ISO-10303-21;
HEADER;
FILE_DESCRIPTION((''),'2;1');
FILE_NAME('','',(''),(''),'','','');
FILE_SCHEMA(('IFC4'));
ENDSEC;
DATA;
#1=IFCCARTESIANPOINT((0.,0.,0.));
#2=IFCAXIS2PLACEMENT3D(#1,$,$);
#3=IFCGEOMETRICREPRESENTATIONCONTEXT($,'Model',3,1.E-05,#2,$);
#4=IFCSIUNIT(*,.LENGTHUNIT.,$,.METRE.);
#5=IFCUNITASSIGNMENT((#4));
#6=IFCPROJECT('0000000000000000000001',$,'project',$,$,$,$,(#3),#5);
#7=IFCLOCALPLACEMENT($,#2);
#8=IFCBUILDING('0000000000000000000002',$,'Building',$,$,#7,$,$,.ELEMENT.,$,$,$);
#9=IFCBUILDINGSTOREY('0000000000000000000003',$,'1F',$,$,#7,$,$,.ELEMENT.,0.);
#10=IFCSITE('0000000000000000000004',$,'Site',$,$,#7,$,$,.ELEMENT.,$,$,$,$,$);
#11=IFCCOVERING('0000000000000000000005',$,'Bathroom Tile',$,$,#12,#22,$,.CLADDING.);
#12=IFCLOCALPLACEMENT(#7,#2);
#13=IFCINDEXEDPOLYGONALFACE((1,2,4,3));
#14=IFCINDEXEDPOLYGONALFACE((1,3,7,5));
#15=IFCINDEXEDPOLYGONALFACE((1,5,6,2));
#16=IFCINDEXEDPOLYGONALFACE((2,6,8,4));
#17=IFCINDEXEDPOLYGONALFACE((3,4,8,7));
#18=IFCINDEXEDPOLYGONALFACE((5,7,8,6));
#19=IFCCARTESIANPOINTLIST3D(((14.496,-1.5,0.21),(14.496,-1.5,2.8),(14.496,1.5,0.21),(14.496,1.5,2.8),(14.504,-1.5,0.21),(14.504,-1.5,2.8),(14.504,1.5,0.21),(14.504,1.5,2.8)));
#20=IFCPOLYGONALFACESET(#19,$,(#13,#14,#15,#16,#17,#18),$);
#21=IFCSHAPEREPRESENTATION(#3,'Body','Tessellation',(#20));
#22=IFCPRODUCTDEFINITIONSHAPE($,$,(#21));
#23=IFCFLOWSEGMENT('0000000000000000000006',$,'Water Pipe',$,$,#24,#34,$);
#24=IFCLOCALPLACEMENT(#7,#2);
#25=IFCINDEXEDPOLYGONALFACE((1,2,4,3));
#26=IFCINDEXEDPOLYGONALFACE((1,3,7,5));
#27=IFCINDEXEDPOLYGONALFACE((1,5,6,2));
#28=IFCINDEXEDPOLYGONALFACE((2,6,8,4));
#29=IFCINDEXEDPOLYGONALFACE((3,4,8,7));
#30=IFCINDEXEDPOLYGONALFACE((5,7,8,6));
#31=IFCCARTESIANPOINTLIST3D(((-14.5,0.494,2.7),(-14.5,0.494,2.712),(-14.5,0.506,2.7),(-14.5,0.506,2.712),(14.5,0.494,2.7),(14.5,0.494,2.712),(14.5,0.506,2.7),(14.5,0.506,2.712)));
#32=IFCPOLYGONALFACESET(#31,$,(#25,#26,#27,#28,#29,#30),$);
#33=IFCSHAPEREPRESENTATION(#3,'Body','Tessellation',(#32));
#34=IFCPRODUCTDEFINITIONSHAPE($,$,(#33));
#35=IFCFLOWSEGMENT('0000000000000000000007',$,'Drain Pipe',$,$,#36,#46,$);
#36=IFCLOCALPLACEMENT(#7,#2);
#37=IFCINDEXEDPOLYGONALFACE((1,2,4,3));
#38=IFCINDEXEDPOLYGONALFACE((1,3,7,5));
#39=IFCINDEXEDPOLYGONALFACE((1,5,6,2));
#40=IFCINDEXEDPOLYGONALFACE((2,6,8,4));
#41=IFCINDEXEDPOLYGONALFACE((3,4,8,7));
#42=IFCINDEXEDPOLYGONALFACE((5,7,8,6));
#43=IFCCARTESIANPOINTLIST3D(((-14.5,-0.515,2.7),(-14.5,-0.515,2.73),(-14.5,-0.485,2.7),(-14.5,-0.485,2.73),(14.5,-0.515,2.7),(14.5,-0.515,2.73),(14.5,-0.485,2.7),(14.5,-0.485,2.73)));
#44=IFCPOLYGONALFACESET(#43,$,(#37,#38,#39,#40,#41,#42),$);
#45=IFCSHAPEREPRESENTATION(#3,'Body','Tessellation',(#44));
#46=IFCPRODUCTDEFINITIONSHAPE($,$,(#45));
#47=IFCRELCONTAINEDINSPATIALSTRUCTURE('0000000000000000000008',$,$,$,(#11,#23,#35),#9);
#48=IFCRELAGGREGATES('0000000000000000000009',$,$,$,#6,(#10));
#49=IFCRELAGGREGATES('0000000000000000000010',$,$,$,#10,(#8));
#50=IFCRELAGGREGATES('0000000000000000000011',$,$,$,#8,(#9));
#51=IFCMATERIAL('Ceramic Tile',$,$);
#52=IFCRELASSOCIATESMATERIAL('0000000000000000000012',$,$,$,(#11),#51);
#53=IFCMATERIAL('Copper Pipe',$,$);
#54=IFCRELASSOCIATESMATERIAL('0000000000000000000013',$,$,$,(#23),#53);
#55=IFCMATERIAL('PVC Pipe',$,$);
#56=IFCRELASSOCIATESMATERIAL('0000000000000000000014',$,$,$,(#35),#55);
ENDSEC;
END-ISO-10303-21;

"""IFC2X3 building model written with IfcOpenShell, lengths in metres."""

from ifc_helpers import new_model, si_unit, frame, origin, origin_2d, place, context, project, spatial, rectangle, extrude, material, element, save


model = new_model("IFC2X3")

# Units and contexts
model_context = context("Model", 3, precision=1e-05, world=origin())
ifc_project = project(units=[si_unit("LENGTHUNIT", "METRE")], contexts=[model_context])

# Site, building, storey
placement = place(None, origin())
site = spatial("IfcSite", under=ifc_project, at=placement, Name="Site", CompositionType="ELEMENT")
building = spatial("IfcBuilding", under=site, at=placement, Name="Building", CompositionType="ELEMENT")
storey = spatial("IfcBuildingStorey", under=building, at=placement, Name="1F", CompositionType="ELEMENT", Elevation=0.0)

# Covering
ifc_material_1 = material(Name="Ceramic Tile")
covering_1_placement = place(None, frame((14.5, 0.0, 0.21)))
element("IfcCovering", 1, at=covering_1_placement, inside=storey, material=ifc_material_1, Name="Bathroom Tile", PredefinedType="CLADDING", context=model_context, shape_type="SweptSolid", body=[
    extrude(rectangle(XDim=0.008, YDim=3.0, at=origin_2d()), origin(), (0.0, 0.0, 1.0), 2.59),
])

# Flow segments
ifc_material_2 = material(Name="Copper Pipe")
flow_segment_1_placement = place(None, frame((0.0, 0.5, 2.7)))
element("IfcFlowSegment", 2, at=flow_segment_1_placement, inside=storey, material=ifc_material_2, Name="Water Pipe", context=model_context, shape_type="SweptSolid", body=[
    extrude(rectangle(XDim=29.0, YDim=0.012, at=origin_2d()), origin(), (0.0, 0.0, 1.0), 0.012),
])
ifc_material_3 = material(Name="PVC Pipe")
flow_segment_2_placement = place(None, frame((0.0, -0.5, 2.7)))
element("IfcFlowSegment", 3, at=flow_segment_2_placement, inside=storey, material=ifc_material_3, Name="Drain Pipe", context=model_context, shape_type="SweptSolid", body=[
    extrude(rectangle(XDim=29.0, YDim=0.03, at=origin_2d()), origin(), (0.0, 0.0, 1.0), 0.03),
])

save(model, "model.ifc")
